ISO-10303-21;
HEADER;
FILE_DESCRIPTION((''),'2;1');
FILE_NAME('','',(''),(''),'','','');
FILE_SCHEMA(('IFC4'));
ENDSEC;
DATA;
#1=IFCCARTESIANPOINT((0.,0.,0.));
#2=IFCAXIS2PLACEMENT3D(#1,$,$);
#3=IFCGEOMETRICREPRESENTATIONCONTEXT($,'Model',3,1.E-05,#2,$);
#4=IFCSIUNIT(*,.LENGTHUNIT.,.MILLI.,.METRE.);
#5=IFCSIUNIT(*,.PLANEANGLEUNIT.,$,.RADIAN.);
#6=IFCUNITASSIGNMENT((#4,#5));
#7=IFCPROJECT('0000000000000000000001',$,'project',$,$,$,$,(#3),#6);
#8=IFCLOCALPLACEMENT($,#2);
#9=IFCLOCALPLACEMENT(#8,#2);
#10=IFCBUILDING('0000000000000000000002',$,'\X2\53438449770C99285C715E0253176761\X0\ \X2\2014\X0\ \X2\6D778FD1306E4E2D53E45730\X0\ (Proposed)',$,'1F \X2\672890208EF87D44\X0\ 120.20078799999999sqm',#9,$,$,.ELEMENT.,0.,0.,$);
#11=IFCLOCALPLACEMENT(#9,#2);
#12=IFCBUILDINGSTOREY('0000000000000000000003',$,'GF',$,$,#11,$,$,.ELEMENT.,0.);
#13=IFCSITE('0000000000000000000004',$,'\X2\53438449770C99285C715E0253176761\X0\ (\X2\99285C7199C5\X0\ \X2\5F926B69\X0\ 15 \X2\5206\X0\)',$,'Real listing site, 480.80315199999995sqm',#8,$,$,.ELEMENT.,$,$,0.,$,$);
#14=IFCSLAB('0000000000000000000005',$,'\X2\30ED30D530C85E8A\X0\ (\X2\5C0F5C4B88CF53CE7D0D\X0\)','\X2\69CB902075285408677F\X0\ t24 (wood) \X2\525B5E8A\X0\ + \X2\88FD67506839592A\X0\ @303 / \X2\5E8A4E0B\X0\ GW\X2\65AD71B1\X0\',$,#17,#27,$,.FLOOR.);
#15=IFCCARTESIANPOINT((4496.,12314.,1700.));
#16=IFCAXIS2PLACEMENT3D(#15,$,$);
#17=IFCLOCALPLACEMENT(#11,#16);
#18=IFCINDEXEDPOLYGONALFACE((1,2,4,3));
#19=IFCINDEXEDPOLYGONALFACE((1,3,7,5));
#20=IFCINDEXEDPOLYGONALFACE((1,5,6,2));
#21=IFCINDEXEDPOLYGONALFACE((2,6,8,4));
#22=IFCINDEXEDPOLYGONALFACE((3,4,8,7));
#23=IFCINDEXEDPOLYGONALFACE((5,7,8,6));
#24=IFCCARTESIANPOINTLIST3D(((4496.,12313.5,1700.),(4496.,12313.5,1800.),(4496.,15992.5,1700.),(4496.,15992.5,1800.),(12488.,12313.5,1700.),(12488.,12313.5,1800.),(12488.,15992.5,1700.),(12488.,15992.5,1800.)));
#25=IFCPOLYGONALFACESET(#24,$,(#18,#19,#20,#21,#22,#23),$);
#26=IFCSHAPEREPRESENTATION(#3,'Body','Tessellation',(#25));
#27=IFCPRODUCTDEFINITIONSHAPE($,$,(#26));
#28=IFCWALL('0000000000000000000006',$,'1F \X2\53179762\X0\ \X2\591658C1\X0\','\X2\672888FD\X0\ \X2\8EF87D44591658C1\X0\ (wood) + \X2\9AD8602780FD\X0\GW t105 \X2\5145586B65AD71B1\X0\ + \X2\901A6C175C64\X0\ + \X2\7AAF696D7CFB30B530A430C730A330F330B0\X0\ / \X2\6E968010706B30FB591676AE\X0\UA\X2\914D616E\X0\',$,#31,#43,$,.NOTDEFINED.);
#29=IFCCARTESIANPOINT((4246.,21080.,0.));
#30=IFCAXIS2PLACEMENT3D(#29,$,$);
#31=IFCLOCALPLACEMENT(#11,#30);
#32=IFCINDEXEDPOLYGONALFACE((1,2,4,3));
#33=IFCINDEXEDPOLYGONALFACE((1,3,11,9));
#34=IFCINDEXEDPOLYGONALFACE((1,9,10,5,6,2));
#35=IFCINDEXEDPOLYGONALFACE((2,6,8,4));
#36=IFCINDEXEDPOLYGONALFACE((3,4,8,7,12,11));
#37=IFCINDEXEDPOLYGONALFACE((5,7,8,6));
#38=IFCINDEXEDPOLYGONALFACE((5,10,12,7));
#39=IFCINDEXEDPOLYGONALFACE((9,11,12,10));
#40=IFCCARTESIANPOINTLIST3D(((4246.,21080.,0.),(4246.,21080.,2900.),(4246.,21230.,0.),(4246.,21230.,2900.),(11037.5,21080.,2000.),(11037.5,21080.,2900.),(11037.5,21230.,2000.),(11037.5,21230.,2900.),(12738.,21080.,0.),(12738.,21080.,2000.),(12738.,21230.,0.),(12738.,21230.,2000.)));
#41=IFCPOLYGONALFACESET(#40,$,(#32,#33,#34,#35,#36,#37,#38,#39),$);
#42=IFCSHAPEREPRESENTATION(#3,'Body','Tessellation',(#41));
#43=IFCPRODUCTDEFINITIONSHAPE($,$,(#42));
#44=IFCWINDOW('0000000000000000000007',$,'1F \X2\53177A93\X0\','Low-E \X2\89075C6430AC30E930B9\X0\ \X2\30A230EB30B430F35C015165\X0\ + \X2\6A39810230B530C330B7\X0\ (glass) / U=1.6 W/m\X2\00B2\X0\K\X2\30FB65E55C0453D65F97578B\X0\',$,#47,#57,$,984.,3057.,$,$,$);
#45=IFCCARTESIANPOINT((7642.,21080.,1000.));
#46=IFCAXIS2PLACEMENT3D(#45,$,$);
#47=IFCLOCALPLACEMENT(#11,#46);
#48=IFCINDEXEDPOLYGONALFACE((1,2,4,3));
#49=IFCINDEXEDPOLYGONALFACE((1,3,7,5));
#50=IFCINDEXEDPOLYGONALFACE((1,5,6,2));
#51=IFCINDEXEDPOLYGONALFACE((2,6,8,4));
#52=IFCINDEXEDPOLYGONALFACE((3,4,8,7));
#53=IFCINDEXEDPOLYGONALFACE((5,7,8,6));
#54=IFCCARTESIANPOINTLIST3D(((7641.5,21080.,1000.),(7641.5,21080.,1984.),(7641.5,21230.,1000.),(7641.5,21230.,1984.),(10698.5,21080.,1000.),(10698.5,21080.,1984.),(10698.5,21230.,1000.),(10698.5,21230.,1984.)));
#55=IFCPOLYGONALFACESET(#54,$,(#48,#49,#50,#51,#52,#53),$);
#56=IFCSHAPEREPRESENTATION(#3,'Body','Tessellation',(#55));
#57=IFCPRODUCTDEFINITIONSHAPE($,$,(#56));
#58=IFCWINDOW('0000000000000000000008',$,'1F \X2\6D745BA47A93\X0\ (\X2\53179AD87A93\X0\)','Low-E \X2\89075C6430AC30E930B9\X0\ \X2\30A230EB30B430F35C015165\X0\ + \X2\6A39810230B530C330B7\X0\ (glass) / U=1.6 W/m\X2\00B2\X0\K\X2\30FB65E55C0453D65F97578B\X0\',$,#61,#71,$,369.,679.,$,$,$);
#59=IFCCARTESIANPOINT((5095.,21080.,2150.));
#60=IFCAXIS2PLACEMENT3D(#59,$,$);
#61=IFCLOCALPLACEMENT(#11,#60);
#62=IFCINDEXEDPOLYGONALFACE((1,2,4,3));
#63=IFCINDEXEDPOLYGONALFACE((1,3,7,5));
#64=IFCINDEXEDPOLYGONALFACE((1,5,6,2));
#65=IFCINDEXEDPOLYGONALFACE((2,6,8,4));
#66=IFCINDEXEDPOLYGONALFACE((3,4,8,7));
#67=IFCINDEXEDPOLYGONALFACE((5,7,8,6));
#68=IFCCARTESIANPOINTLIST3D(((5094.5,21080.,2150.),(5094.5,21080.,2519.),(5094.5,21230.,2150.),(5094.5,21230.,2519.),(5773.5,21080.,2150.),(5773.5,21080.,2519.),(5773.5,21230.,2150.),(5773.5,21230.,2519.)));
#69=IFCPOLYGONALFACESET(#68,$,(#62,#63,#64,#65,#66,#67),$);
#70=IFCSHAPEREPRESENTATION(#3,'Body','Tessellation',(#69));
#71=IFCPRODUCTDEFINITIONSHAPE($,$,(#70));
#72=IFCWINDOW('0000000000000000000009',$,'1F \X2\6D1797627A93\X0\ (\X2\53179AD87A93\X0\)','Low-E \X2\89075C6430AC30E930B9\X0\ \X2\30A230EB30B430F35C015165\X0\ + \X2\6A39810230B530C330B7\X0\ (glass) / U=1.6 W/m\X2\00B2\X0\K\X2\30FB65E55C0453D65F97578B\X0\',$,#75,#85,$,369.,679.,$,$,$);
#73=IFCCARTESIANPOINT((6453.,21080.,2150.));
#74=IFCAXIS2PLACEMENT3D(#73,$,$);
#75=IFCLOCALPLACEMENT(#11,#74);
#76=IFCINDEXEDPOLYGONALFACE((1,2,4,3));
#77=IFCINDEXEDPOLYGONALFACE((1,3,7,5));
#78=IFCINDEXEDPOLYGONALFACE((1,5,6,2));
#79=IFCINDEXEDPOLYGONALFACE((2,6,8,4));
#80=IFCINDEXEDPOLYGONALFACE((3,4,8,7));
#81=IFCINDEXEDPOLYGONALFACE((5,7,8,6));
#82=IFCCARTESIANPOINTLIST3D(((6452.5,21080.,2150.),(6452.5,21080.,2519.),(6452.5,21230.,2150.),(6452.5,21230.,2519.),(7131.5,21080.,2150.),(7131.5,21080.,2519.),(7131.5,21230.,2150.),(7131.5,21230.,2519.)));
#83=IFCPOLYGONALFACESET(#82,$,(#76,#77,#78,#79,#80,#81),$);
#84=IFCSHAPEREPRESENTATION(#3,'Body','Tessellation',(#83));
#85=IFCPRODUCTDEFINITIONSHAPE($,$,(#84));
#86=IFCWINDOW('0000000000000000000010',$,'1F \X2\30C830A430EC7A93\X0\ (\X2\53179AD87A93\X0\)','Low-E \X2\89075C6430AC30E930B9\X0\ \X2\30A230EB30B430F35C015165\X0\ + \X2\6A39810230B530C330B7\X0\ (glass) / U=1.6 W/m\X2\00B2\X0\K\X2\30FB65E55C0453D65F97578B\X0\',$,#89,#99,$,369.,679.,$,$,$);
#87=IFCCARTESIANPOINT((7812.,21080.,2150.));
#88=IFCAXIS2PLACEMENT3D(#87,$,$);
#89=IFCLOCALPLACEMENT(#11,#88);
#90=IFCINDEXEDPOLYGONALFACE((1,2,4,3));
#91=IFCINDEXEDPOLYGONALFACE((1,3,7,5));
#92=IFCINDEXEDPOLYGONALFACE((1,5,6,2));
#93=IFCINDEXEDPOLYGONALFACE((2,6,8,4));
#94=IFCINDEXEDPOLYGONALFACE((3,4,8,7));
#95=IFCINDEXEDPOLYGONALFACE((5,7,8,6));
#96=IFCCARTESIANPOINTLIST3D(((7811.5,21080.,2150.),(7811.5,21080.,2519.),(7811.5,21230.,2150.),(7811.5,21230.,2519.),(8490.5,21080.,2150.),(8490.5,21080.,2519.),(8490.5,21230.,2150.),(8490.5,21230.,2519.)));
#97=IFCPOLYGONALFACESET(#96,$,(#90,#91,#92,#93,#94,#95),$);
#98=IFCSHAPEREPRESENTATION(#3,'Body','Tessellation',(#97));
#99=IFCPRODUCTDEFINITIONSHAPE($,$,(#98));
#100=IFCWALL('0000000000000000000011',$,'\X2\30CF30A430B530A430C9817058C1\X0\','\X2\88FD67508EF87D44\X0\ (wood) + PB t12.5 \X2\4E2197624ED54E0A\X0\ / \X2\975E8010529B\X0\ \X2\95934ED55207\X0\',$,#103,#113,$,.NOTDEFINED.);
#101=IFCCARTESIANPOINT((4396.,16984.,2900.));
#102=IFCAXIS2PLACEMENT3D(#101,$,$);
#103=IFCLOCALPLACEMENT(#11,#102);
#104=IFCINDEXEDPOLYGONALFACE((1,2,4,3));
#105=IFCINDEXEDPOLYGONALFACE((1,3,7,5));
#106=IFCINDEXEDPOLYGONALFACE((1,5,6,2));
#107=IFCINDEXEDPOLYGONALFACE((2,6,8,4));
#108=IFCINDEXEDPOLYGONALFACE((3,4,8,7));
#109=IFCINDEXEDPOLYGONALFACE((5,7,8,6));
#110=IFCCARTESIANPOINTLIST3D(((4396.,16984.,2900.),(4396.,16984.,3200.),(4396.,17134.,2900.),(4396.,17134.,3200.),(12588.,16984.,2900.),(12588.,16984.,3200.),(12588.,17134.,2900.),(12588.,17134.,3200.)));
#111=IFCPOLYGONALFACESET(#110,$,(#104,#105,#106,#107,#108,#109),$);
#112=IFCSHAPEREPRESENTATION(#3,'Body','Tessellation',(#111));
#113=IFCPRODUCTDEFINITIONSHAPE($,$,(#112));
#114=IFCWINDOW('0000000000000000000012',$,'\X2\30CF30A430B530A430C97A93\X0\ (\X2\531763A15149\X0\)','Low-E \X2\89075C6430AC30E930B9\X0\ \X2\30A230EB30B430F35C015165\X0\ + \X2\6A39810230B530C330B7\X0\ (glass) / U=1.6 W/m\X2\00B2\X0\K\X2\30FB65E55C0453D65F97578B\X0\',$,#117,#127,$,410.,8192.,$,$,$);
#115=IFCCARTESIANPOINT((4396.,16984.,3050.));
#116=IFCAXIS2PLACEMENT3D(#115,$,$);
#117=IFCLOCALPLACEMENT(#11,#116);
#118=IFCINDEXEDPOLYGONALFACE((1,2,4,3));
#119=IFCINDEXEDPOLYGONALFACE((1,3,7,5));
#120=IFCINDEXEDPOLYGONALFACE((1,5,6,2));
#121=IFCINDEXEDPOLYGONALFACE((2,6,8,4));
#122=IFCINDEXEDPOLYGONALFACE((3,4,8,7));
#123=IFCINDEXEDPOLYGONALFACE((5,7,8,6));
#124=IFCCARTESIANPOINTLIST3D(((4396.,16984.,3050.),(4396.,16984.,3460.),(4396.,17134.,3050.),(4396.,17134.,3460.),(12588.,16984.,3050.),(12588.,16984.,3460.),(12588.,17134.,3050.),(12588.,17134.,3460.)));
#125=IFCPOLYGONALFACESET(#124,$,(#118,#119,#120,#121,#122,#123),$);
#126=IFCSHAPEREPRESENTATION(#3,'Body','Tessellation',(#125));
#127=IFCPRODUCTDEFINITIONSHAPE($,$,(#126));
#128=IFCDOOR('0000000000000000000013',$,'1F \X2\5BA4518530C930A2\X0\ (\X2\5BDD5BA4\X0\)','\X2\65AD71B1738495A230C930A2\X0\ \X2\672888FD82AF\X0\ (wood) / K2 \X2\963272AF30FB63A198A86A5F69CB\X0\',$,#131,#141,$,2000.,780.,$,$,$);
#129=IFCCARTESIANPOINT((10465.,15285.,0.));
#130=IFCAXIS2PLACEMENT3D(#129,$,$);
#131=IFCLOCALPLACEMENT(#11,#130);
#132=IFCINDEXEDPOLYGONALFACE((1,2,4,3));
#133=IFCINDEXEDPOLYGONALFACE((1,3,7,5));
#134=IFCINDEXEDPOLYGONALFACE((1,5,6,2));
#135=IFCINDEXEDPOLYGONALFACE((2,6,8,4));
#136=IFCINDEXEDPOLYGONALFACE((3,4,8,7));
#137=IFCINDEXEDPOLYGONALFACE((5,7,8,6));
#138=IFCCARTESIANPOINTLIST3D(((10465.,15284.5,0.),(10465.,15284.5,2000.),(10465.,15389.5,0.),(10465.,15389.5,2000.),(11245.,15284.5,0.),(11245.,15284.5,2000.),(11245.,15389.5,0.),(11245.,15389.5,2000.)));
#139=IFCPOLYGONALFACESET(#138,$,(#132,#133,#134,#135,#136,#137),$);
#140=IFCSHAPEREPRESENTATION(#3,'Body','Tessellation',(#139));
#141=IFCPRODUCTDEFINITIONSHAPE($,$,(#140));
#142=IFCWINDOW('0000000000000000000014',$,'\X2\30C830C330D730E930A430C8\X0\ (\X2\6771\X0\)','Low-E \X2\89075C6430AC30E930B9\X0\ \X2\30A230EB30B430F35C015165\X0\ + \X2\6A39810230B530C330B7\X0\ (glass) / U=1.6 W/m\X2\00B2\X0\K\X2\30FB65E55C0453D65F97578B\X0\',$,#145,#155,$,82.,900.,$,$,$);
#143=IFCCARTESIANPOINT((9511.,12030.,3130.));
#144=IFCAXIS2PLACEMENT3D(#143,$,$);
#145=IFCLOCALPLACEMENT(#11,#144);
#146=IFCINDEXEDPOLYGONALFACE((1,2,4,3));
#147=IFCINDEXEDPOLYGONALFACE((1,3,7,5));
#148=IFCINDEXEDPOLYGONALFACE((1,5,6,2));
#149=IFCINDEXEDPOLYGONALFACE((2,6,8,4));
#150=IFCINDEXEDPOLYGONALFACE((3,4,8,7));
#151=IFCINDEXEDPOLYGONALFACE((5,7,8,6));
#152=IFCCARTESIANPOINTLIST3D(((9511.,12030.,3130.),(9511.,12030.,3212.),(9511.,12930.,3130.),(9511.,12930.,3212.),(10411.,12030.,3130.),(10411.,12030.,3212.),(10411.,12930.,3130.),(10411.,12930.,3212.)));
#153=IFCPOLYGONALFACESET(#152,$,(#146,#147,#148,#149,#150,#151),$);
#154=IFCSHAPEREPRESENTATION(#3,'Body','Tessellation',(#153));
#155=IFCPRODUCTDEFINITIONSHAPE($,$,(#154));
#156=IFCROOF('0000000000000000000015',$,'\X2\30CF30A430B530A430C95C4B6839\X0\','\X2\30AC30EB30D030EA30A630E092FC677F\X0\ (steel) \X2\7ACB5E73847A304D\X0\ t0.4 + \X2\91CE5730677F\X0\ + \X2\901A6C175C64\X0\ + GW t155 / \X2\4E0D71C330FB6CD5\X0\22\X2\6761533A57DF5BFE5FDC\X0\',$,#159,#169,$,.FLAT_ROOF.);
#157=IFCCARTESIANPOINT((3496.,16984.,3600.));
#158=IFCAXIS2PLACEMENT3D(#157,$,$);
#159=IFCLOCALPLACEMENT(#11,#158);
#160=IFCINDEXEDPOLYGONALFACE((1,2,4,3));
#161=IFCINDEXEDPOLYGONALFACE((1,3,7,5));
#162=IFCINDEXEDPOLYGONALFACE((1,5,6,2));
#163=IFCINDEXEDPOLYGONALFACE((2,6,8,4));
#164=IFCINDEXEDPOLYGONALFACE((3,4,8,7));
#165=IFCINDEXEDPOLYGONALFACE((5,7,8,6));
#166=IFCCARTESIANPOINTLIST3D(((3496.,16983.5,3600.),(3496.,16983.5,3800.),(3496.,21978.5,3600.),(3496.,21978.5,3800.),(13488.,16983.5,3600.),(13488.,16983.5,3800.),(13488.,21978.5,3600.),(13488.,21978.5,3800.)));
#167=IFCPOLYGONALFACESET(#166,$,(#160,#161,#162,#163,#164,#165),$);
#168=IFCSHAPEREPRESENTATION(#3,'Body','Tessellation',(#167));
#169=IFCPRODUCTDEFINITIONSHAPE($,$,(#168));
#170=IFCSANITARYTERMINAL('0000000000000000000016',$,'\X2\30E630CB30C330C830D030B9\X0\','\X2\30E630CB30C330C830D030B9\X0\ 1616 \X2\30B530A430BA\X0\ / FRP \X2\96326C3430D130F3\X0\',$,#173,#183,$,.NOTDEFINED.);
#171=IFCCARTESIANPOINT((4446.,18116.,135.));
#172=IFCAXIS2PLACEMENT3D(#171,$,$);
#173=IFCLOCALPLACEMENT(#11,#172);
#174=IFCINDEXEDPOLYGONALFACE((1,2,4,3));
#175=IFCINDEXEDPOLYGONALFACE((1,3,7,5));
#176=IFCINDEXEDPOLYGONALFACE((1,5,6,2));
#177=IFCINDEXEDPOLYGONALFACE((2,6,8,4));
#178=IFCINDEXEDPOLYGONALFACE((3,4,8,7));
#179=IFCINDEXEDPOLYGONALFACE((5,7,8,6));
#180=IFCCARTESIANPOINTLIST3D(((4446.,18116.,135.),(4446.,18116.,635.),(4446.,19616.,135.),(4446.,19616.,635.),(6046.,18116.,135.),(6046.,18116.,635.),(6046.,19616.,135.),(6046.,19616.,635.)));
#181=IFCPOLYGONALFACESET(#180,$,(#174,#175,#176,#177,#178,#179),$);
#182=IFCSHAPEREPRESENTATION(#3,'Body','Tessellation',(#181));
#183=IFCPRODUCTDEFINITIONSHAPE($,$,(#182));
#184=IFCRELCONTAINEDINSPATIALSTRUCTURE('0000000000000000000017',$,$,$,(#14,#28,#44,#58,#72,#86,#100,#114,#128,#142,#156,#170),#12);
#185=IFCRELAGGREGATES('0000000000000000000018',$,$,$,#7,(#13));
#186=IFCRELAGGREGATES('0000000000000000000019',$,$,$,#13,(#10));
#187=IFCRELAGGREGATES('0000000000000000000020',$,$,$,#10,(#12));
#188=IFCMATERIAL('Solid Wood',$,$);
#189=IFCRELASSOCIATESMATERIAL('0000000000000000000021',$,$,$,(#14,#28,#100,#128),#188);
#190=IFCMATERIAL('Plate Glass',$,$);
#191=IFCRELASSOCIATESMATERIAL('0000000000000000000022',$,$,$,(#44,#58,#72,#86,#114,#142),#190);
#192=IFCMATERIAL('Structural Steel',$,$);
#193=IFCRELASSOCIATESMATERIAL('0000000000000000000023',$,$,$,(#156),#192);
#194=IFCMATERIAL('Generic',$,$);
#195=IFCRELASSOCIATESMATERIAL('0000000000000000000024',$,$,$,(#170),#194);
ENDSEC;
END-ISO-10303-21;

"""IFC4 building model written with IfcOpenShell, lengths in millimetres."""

from ifc_helpers import new_model, si_unit, frame, frame_2d, origin, place, context, project, spatial, rectangle, extrude, material, element, fill, save


model = new_model("IFC4")

# Units and contexts
model_context = context("Model", 3, precision=1e-05, world=origin())
ifc_project = project(units=[si_unit("LENGTHUNIT", "METRE", prefix="MILLI"), si_unit("PLANEANGLEUNIT", "RADIAN")], contexts=[model_context])

# Site, building, storey
site_placement = place(None, origin())
site = spatial("IfcSite", under=ifc_project, at=site_placement, Name="千葉県館山市北条 (館山駅 徒歩 15 分)", ObjectType="Real listing site, 480.80315199999995sqm", CompositionType="ELEMENT", RefElevation=0.0)
building_placement = place(site_placement, origin())
building = spatial("IfcBuilding", under=site, at=building_placement, Name="千葉県館山市北条 — 海近の中古地 (Proposed)", ObjectType="1F 木造軸組 120.20078799999999sqm", CompositionType="ELEMENT", ElevationOfRefHeight=0.0, ElevationOfTerrain=0.0)
storey_placement = place(building_placement, origin())
storey = spatial("IfcBuildingStorey", under=building, at=storey_placement, Name="GF", CompositionType="ELEMENT", Elevation=0.0)

# Slab
ifc_material_1 = material(Name="Solid Wood")
slab_placement = place(storey_placement, frame((4496.0, 12314.0, 1700.0)))
element("IfcSlab", 1, at=slab_placement, inside=storey, material=ifc_material_1, Name="ロフト床 (小屋裏収納)", Description="構造用合板 t24 (wood) 剛床 + 製材根太 @303 / 床下 GW断熱", PredefinedType="FLOOR", context=model_context, shape_type="SweptSolid", body=[
    extrude(rectangle(XDim=7992.0, YDim=3679.0, at=frame_2d((3996.0, 1839.0))), frame((4496.0, 12314.0, 1700.0)), (0.0, 0.0, 1.0), 100.0),
])

# Wall, openings, windows
wall_1_placement = place(storey_placement, frame((4246.0, 21080.0, 0.0)))
wall_1 = element("IfcWall", 2, at=wall_1_placement, inside=storey, material=ifc_material_1, Name="1F 北面 外壁", Description="木製 軸組外壁 (wood) + 高性能GW t105 充填断熱 + 通気層 + 窯業系サイディング / 準耐火・外皮UA配慮", PredefinedType="NOTDEFINED", context=model_context, shape_type="SweptSolid", body=[
    extrude(rectangle(XDim=8492.0, YDim=150.0, at=frame_2d((4246.0, 75.0))), frame((4246.0, 21080.0, 0.0)), (0.0, 0.0, 1.0), 2900.0),
])
opening_1_placement = place(storey_placement, frame((7642.0, 21080.0, 1000.0)))
opening_1 = element("IfcOpeningElement", 3, at=opening_1_placement, cuts=wall_1, PredefinedType="NOTDEFINED", context=model_context, shape_type="SweptSolid", body=[
    extrude(rectangle(XDim=3057.0, YDim=150.0, at=frame_2d((1528.0, 75.0))), frame((7642.0, 21080.0, 1000.0)), (0.0, 0.0, 1.0), 984.0),
])
opening_2_placement = place(storey_placement, frame((5095.0, 21080.0, 2150.0)))
opening_2 = element("IfcOpeningElement", 4, at=opening_2_placement, cuts=wall_1, PredefinedType="NOTDEFINED", context=model_context, shape_type="SweptSolid", body=[
    extrude(rectangle(XDim=679.0, YDim=150.0, at=frame_2d((339.0, 75.0))), frame((5095.0, 21080.0, 2150.0)), (0.0, 0.0, 1.0), 369.0),
])
opening_3_placement = place(storey_placement, frame((6453.0, 21080.0, 2150.0)))
opening_3 = element("IfcOpeningElement", 5, at=opening_3_placement, cuts=wall_1, PredefinedType="NOTDEFINED", context=model_context, shape_type="SweptSolid", body=[
    extrude(rectangle(XDim=679.0, YDim=150.0, at=frame_2d((339.0, 75.0))), frame((6453.0, 21080.0, 2150.0)), (0.0, 0.0, 1.0), 369.0),
])
opening_4_placement = place(storey_placement, frame((7812.0, 21080.0, 2150.0)))
opening_4 = element("IfcOpeningElement", 6, at=opening_4_placement, cuts=wall_1, PredefinedType="NOTDEFINED", context=model_context, shape_type="SweptSolid", body=[
    extrude(rectangle(XDim=679.0, YDim=150.0, at=frame_2d((339.0, 75.0))), frame((7812.0, 21080.0, 2150.0)), (0.0, 0.0, 1.0), 369.0),
])
ifc_material_2 = material(Name="Plate Glass")
window_1_placement = place(storey_placement, frame((7642.0, 21080.0, 1000.0)))
window_1 = element("IfcWindow", 7, at=window_1_placement, inside=storey, material=ifc_material_2, Name="1F 北窓", Description="Low-E 複層ガラス アルゴン封入 + 樹脂サッシ (glass) / U=1.6 W/m²K・日射取得型", OverallHeight=984.0, OverallWidth=3057.0, context=model_context, shape_type="SweptSolid", body=[
    extrude(rectangle(XDim=3057.0, YDim=150.0, at=frame_2d((1528.0, 75.0))), frame((7642.0, 21080.0, 1000.0)), (0.0, 0.0, 1.0), 984.0),
])
fill(opening_1, window_1)
window_2_placement = place(storey_placement, frame((5095.0, 21080.0, 2150.0)))
window_2 = element("IfcWindow", 8, at=window_2_placement, inside=storey, material=ifc_material_2, Name="1F 浴室窓 (北高窓)", Description="Low-E 複層ガラス アルゴン封入 + 樹脂サッシ (glass) / U=1.6 W/m²K・日射取得型", OverallHeight=369.0, OverallWidth=679.0, context=model_context, shape_type="SweptSolid", body=[
    extrude(rectangle(XDim=679.0, YDim=150.0, at=frame_2d((339.0, 75.0))), frame((5095.0, 21080.0, 2150.0)), (0.0, 0.0, 1.0), 369.0),
])
fill(opening_2, window_2)
window_3_placement = place(storey_placement, frame((6453.0, 21080.0, 2150.0)))
window_3 = element("IfcWindow", 9, at=window_3_placement, inside=storey, material=ifc_material_2, Name="1F 洗面窓 (北高窓)", Description="Low-E 複層ガラス アルゴン封入 + 樹脂サッシ (glass) / U=1.6 W/m²K・日射取得型", OverallHeight=369.0, OverallWidth=679.0, context=model_context, shape_type="SweptSolid", body=[
    extrude(rectangle(XDim=679.0, YDim=150.0, at=frame_2d((339.0, 75.0))), frame((6453.0, 21080.0, 2150.0)), (0.0, 0.0, 1.0), 369.0),
])
fill(opening_3, window_3)
window_4_placement = place(storey_placement, frame((7812.0, 21080.0, 2150.0)))
window_4 = element("IfcWindow", 10, at=window_4_placement, inside=storey, material=ifc_material_2, Name="1F トイレ窓 (北高窓)", Description="Low-E 複層ガラス アルゴン封入 + 樹脂サッシ (glass) / U=1.6 W/m²K・日射取得型", OverallHeight=369.0, OverallWidth=679.0, context=model_context, shape_type="SweptSolid", body=[
    extrude(rectangle(XDim=679.0, YDim=150.0, at=frame_2d((339.0, 75.0))), frame((7812.0, 21080.0, 2150.0)), (0.0, 0.0, 1.0), 369.0),
])
fill(opening_4, window_4)

# Wall, opening, window
wall_2_placement = place(storey_placement, frame((4396.0, 16984.0, 2900.0)))
wall_2 = element("IfcWall", 11, at=wall_2_placement, inside=storey, material=ifc_material_1, Name="ハイサイド腰壁", Description="製材軸組 (wood) + PB t12.5 両面仕上 / 非耐力 間仕切", PredefinedType="NOTDEFINED", context=model_context, shape_type="SweptSolid", body=[
    extrude(rectangle(XDim=8192.0, YDim=150.0, at=frame_2d((4096.0, 75.0))), frame((4396.0, 16984.0, 2900.0)), (0.0, 0.0, 1.0), 700.0),
])
opening_5_placement = place(storey_placement, frame((4396.0, 16984.0, 3050.0)))
opening_5 = element("IfcOpeningElement", 12, at=opening_5_placement, cuts=wall_2, PredefinedType="NOTDEFINED", context=model_context, shape_type="SweptSolid", body=[
    extrude(rectangle(XDim=8192.0, YDim=150.0, at=frame_2d((4096.0, 75.0))), frame((4396.0, 16984.0, 3050.0)), (0.0, 0.0, 1.0), 410.0),
])
window_5_placement = place(storey_placement, frame((4396.0, 16984.0, 3050.0)))
window_5 = element("IfcWindow", 13, at=window_5_placement, inside=storey, material=ifc_material_2, Name="ハイサイド窓 (北採光)", Description="Low-E 複層ガラス アルゴン封入 + 樹脂サッシ (glass) / U=1.6 W/m²K・日射取得型", OverallHeight=410.0, OverallWidth=8192.0, context=model_context, shape_type="SweptSolid", body=[
    extrude(rectangle(XDim=8192.0, YDim=150.0, at=frame_2d((4096.0, 75.0))), frame((4396.0, 16984.0, 3050.0)), (0.0, 0.0, 1.0), 410.0),
])
fill(opening_5, window_5)

# Door
door_1_placement = place(storey_placement, frame((10465.0, 15285.0, 0.0)))
element("IfcDoor", 14, at=door_1_placement, inside=storey, material=ifc_material_1, Name="1F 室内ドア (寝室)", Description="断熱玄関ドア 木製芯 (wood) / K2 防犯・採風機構", OverallHeight=2000.0, OverallWidth=780.0, context=model_context, shape_type="SweptSolid", body=[
    extrude(rectangle(XDim=780.0, YDim=105.0, at=frame_2d((390.0, 52.0))), frame((10465.0, 15285.0, 0.0)), (0.0, 0.0, 1.0), 2000.0),
])

# Window
window_6_placement = place(storey_placement, frame((9511.0, 12030.0, 3130.0)))
element("IfcWindow", 15, at=window_6_placement, inside=storey, material=ifc_material_2, Name="トップライト (東)", Description="Low-E 複層ガラス アルゴン封入 + 樹脂サッシ (glass) / U=1.6 W/m²K・日射取得型", OverallHeight=82.0, OverallWidth=900.0, context=model_context, shape_type="SweptSolid", body=[
    extrude(rectangle(XDim=900.0, YDim=900.0, at=frame_2d((450.0, 450.0))), frame((9511.0, 12030.0, 3130.0)), (0.0, 0.0, 1.0), 82.0),
])

# Roof
ifc_material_3 = material(Name="Structural Steel")
roof_placement = place(storey_placement, frame((3496.0, 16984.0, 3600.0)))
element("IfcRoof", 16, at=roof_placement, inside=storey, material=ifc_material_3, Name="ハイサイド屋根", Description="ガルバリウム鋼板 (steel) 立平葺き t0.4 + 野地板 + 通気層 + GW t155 / 不燃・法22条区域対応", PredefinedType="FLAT_ROOF", context=model_context, shape_type="SweptSolid", body=[
    extrude(rectangle(XDim=9992.0, YDim=4995.0, at=frame_2d((4996.0, 2497.0))), frame((3496.0, 16984.0, 3600.0)), (0.0, 0.0, 1.0), 200.0),
])

# Sanitary terminal
ifc_material_4 = material(Name="Generic")
sanitary_terminal_1_placement = place(storey_placement, frame((4446.0, 18116.0, 135.0)))
element("IfcSanitaryTerminal", 17, at=sanitary_terminal_1_placement, inside=storey, material=ifc_material_4, Name="ユニットバス", Description="ユニットバス 1616 サイズ / FRP 防水パン", PredefinedType="NOTDEFINED", context=model_context, shape_type="SweptSolid", body=[
    extrude(rectangle(XDim=1600.0, YDim=1500.0, at=frame_2d((800.0, 750.0))), frame((4446.0, 18116.0, 135.0)), (0.0, 0.0, 1.0), 500.0),
])

save(model, "model.ifc")
